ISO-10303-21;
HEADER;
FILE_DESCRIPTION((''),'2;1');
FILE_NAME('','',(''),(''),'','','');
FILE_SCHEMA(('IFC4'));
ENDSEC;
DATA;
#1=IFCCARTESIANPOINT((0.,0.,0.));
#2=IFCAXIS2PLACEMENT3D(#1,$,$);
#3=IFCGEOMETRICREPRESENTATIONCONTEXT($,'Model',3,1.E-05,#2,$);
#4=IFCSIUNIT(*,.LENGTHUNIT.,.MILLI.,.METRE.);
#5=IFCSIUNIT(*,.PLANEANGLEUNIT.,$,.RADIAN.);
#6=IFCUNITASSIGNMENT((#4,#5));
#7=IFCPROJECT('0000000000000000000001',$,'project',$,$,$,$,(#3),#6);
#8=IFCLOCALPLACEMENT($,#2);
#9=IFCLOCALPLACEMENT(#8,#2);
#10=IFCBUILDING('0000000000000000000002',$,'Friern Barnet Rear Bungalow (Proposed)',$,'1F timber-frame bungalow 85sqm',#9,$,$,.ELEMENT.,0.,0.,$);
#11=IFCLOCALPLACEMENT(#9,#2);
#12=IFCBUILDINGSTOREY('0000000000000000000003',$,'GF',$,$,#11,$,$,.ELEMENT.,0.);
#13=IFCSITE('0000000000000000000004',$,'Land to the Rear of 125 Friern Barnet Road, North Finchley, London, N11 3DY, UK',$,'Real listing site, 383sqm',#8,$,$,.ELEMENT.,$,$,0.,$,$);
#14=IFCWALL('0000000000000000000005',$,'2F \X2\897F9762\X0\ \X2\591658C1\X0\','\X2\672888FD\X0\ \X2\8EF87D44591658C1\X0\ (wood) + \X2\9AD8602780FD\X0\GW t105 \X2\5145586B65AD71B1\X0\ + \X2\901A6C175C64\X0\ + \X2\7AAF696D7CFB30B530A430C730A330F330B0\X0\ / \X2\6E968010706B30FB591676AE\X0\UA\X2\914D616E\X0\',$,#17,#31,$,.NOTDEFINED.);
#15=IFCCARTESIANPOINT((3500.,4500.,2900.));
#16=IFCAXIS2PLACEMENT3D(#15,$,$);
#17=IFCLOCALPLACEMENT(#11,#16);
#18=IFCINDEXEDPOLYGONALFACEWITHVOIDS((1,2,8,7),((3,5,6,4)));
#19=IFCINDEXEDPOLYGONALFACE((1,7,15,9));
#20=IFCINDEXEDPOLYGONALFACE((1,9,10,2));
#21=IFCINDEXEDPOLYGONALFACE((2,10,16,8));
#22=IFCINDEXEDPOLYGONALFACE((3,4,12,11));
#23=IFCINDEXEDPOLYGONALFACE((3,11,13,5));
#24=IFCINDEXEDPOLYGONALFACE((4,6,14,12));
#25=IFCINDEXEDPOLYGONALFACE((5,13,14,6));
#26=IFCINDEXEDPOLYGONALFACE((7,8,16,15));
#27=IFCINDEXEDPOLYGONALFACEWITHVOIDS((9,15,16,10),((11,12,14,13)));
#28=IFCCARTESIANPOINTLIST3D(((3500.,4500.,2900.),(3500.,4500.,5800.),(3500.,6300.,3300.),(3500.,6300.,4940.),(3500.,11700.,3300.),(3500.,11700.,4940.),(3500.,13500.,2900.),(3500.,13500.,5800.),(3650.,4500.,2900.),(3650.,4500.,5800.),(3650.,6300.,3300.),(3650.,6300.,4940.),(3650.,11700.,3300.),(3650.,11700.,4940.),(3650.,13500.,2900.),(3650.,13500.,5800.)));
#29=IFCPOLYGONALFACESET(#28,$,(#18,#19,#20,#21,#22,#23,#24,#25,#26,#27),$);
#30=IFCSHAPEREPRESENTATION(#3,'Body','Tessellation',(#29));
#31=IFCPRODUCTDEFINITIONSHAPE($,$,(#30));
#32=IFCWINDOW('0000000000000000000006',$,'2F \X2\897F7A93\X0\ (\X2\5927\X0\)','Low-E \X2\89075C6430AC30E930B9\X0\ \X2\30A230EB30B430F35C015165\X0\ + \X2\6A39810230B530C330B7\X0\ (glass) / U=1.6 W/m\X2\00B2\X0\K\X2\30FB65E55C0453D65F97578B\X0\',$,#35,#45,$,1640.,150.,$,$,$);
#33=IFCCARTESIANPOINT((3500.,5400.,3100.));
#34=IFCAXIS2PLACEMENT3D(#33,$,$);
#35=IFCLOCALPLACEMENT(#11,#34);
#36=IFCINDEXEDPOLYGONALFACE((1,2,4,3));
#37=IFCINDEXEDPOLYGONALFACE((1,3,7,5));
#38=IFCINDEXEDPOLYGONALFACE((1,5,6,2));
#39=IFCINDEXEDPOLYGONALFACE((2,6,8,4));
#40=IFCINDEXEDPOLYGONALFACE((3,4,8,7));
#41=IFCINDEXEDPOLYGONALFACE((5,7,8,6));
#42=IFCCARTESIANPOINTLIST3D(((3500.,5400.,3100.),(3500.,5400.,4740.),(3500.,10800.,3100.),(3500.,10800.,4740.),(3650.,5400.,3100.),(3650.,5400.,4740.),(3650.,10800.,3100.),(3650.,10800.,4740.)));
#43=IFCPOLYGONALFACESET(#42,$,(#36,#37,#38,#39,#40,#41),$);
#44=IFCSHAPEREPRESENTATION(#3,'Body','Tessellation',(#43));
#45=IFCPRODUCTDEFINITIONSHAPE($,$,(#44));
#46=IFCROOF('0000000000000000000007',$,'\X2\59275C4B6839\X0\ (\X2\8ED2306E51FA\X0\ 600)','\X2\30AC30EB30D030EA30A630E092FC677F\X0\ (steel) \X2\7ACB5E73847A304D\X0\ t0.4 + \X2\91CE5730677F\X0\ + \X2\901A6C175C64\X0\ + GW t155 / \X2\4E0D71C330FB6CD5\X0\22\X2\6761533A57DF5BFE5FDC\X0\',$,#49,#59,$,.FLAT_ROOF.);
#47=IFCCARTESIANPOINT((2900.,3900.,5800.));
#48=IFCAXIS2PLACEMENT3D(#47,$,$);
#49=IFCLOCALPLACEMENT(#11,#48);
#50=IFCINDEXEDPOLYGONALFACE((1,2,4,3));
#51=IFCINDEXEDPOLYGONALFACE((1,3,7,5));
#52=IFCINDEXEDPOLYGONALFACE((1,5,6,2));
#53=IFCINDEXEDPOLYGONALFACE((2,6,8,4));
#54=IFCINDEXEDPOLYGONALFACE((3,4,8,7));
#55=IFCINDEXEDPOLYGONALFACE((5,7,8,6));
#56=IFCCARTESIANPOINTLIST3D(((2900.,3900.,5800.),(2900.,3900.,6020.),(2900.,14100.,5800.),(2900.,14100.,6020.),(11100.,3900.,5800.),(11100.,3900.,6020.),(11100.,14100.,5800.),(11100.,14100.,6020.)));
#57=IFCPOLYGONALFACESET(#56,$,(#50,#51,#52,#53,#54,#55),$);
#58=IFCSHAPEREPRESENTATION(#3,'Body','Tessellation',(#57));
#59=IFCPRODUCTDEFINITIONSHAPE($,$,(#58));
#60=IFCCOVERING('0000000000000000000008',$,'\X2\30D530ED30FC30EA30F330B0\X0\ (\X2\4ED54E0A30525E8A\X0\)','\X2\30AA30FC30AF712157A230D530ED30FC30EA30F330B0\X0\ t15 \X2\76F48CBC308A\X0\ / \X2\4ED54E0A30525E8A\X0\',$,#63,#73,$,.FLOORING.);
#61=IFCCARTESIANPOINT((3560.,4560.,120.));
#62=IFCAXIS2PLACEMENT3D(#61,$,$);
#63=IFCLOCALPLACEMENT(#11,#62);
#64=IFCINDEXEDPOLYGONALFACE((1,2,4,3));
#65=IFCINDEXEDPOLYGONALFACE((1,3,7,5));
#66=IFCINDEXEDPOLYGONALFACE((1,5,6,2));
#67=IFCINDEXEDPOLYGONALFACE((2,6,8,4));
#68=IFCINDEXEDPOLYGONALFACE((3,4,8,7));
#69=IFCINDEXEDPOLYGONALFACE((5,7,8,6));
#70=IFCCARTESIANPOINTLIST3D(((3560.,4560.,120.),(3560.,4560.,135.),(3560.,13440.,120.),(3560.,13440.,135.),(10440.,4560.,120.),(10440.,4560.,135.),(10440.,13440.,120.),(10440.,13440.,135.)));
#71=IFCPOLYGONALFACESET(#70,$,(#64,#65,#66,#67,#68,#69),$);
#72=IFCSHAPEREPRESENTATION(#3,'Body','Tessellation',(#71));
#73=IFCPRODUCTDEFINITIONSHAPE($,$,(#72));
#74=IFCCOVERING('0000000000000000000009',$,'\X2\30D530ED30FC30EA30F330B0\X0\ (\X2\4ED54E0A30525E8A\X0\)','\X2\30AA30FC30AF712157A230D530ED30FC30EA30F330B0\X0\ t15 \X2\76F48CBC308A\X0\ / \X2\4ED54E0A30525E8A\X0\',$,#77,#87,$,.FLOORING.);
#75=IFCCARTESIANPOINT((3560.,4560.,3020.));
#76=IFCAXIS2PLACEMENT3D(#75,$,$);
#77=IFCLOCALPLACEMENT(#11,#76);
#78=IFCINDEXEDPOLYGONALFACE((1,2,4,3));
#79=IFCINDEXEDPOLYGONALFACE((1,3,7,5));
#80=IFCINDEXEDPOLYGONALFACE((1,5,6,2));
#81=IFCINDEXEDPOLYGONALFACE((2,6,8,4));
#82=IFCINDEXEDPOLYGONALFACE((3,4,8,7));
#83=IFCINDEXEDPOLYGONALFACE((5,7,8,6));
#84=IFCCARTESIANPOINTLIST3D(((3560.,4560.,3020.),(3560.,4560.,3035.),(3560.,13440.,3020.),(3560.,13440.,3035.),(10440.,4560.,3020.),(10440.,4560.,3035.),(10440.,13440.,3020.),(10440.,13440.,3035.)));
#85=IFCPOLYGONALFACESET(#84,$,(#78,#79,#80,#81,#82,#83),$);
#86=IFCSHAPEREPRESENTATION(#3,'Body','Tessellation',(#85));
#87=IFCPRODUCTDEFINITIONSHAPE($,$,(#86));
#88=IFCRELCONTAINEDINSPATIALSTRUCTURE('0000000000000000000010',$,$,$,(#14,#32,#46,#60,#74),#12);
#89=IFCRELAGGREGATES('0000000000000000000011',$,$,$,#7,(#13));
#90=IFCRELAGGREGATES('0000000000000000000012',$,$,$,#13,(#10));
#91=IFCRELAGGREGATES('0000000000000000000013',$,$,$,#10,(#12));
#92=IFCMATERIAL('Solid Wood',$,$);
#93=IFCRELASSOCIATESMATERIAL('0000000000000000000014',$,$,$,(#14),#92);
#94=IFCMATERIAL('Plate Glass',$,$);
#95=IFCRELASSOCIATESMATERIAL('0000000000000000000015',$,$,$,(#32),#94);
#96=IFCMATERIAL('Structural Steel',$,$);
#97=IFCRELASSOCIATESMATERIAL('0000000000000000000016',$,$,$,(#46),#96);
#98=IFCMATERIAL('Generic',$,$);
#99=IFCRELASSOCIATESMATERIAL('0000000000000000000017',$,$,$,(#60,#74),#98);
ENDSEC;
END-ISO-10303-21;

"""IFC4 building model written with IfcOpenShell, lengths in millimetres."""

from ifc_helpers import new_model, si_unit, frame, frame_2d, origin, place, context, project, spatial, rectangle, extrude, material, element, fill, save


model = new_model("IFC4")

# Units and contexts
model_context = context("Model", 3, precision=1e-05, world=origin())
ifc_project = project(units=[si_unit("LENGTHUNIT", "METRE", prefix="MILLI"), si_unit("PLANEANGLEUNIT", "RADIAN")], contexts=[model_context])

# Site, building, storey
site_placement = place(None, origin())
site = spatial("IfcSite", under=ifc_project, at=site_placement, Name="Land to the Rear of 125 Friern Barnet Road, North Finchley, London, N11 3DY, UK", ObjectType="Real listing site, 383sqm", CompositionType="ELEMENT", RefElevation=0.0)
building_placement = place(site_placement, origin())
building = spatial("IfcBuilding", under=site, at=building_placement, Name="Friern Barnet Rear Bungalow (Proposed)", ObjectType="1F timber-frame bungalow 85sqm", CompositionType="ELEMENT", ElevationOfRefHeight=0.0, ElevationOfTerrain=0.0)
storey_placement = place(building_placement, origin())
storey = spatial("IfcBuildingStorey", under=building, at=storey_placement, Name="GF", CompositionType="ELEMENT", Elevation=0.0)

# Shared definitions
ifc_material_1 = material(Name="Solid Wood")
ifc_material_2 = material(Name="Generic")

# Shared definitions
ifc_material_3 = material(Name="Plate Glass")

# Wall, opening, window
wall_1_placement = place(storey_placement, frame((3500.0, 4500.0, 2900.0)))
wall_1 = element("IfcWall", 1, at=wall_1_placement, inside=storey, material=ifc_material_1, Name="2F 西面 外壁", Description="木製 軸組外壁 (wood) + 高性能GW t105 充填断熱 + 通気層 + 窯業系サイディング / 準耐火・外皮UA配慮", PredefinedType="NOTDEFINED", context=model_context, shape_type="SweptSolid", body=[
    extrude(rectangle(XDim=150.0, YDim=9000.0, at=frame_2d((75.0, 4500.0))), frame((3500.0, 4500.0, 2900.0)), (0.0, 0.0, 1.0), 2900.0),
])
opening_1_placement = place(storey_placement, frame((3500.0, 5400.0, 3100.0)))
opening_1 = element("IfcOpeningElement", 2, at=opening_1_placement, cuts=wall_1, PredefinedType="NOTDEFINED", context=model_context, shape_type="SweptSolid", body=[
    extrude(rectangle(XDim=150.0, YDim=5400.0, at=frame_2d((75.0, 2700.0))), frame((3500.0, 5400.0, 3100.0)), (0.0, 0.0, 1.0), 1640.0),
])
window_1_placement = place(storey_placement, frame((3500.0, 5400.0, 3100.0)))
window_1 = element("IfcWindow", 3, at=window_1_placement, inside=storey, material=ifc_material_3, Name="2F 西窓 (大)", Description="Low-E 複層ガラス アルゴン封入 + 樹脂サッシ (glass) / U=1.6 W/m²K・日射取得型", OverallHeight=1640.0, OverallWidth=150.0, context=model_context, shape_type="SweptSolid", body=[
    extrude(rectangle(XDim=150.0, YDim=5400.0, at=frame_2d((75.0, 2700.0))), frame((3500.0, 5400.0, 3100.0)), (0.0, 0.0, 1.0), 1640.0),
])
fill(opening_1, window_1)

# Roof
ifc_material_4 = material(Name="Structural Steel")
roof_placement = place(storey_placement, frame((2900.0, 3900.0, 5800.0)))
element("IfcRoof", 4, at=roof_placement, inside=storey, material=ifc_material_4, Name="大屋根 (軒の出 600)", Description="ガルバリウム鋼板 (steel) 立平葺き t0.4 + 野地板 + 通気層 + GW t155 / 不燃・法22条区域対応", PredefinedType="FLAT_ROOF", context=model_context, shape_type="SweptSolid", body=[
    extrude(rectangle(XDim=8200.0, YDim=10200.0, at=frame_2d((4100.0, 5100.0))), frame((2900.0, 3900.0, 5800.0)), (0.0, 0.0, 1.0), 220.0),
])

# Coverings
covering_1_placement = place(storey_placement, frame((3560.0, 4560.0, 120.0)))
element("IfcCovering", 5, at=covering_1_placement, inside=storey, material=ifc_material_2, Name="フローリング (仕上げ床)", Description="オーク無垢フローリング t15 直貼り / 仕上げ床", PredefinedType="FLOORING", context=model_context, shape_type="SweptSolid", body=[
    extrude(rectangle(XDim=6880.0, YDim=8880.0, at=frame_2d((3440.0, 4440.0))), frame((3560.0, 4560.0, 120.0)), (0.0, 0.0, 1.0), 15.0),
])
covering_2_placement = place(storey_placement, frame((3560.0, 4560.0, 3020.0)))
element("IfcCovering", 6, at=covering_2_placement, inside=storey, material=ifc_material_2, Name="フローリング (仕上げ床)", Description="オーク無垢フローリング t15 直貼り / 仕上げ床", PredefinedType="FLOORING", context=model_context, shape_type="SweptSolid", body=[
    extrude(rectangle(XDim=6880.0, YDim=8880.0, at=frame_2d((3440.0, 4440.0))), frame((3560.0, 4560.0, 3020.0)), (0.0, 0.0, 1.0), 15.0),
])

save(model, "model.ifc")
